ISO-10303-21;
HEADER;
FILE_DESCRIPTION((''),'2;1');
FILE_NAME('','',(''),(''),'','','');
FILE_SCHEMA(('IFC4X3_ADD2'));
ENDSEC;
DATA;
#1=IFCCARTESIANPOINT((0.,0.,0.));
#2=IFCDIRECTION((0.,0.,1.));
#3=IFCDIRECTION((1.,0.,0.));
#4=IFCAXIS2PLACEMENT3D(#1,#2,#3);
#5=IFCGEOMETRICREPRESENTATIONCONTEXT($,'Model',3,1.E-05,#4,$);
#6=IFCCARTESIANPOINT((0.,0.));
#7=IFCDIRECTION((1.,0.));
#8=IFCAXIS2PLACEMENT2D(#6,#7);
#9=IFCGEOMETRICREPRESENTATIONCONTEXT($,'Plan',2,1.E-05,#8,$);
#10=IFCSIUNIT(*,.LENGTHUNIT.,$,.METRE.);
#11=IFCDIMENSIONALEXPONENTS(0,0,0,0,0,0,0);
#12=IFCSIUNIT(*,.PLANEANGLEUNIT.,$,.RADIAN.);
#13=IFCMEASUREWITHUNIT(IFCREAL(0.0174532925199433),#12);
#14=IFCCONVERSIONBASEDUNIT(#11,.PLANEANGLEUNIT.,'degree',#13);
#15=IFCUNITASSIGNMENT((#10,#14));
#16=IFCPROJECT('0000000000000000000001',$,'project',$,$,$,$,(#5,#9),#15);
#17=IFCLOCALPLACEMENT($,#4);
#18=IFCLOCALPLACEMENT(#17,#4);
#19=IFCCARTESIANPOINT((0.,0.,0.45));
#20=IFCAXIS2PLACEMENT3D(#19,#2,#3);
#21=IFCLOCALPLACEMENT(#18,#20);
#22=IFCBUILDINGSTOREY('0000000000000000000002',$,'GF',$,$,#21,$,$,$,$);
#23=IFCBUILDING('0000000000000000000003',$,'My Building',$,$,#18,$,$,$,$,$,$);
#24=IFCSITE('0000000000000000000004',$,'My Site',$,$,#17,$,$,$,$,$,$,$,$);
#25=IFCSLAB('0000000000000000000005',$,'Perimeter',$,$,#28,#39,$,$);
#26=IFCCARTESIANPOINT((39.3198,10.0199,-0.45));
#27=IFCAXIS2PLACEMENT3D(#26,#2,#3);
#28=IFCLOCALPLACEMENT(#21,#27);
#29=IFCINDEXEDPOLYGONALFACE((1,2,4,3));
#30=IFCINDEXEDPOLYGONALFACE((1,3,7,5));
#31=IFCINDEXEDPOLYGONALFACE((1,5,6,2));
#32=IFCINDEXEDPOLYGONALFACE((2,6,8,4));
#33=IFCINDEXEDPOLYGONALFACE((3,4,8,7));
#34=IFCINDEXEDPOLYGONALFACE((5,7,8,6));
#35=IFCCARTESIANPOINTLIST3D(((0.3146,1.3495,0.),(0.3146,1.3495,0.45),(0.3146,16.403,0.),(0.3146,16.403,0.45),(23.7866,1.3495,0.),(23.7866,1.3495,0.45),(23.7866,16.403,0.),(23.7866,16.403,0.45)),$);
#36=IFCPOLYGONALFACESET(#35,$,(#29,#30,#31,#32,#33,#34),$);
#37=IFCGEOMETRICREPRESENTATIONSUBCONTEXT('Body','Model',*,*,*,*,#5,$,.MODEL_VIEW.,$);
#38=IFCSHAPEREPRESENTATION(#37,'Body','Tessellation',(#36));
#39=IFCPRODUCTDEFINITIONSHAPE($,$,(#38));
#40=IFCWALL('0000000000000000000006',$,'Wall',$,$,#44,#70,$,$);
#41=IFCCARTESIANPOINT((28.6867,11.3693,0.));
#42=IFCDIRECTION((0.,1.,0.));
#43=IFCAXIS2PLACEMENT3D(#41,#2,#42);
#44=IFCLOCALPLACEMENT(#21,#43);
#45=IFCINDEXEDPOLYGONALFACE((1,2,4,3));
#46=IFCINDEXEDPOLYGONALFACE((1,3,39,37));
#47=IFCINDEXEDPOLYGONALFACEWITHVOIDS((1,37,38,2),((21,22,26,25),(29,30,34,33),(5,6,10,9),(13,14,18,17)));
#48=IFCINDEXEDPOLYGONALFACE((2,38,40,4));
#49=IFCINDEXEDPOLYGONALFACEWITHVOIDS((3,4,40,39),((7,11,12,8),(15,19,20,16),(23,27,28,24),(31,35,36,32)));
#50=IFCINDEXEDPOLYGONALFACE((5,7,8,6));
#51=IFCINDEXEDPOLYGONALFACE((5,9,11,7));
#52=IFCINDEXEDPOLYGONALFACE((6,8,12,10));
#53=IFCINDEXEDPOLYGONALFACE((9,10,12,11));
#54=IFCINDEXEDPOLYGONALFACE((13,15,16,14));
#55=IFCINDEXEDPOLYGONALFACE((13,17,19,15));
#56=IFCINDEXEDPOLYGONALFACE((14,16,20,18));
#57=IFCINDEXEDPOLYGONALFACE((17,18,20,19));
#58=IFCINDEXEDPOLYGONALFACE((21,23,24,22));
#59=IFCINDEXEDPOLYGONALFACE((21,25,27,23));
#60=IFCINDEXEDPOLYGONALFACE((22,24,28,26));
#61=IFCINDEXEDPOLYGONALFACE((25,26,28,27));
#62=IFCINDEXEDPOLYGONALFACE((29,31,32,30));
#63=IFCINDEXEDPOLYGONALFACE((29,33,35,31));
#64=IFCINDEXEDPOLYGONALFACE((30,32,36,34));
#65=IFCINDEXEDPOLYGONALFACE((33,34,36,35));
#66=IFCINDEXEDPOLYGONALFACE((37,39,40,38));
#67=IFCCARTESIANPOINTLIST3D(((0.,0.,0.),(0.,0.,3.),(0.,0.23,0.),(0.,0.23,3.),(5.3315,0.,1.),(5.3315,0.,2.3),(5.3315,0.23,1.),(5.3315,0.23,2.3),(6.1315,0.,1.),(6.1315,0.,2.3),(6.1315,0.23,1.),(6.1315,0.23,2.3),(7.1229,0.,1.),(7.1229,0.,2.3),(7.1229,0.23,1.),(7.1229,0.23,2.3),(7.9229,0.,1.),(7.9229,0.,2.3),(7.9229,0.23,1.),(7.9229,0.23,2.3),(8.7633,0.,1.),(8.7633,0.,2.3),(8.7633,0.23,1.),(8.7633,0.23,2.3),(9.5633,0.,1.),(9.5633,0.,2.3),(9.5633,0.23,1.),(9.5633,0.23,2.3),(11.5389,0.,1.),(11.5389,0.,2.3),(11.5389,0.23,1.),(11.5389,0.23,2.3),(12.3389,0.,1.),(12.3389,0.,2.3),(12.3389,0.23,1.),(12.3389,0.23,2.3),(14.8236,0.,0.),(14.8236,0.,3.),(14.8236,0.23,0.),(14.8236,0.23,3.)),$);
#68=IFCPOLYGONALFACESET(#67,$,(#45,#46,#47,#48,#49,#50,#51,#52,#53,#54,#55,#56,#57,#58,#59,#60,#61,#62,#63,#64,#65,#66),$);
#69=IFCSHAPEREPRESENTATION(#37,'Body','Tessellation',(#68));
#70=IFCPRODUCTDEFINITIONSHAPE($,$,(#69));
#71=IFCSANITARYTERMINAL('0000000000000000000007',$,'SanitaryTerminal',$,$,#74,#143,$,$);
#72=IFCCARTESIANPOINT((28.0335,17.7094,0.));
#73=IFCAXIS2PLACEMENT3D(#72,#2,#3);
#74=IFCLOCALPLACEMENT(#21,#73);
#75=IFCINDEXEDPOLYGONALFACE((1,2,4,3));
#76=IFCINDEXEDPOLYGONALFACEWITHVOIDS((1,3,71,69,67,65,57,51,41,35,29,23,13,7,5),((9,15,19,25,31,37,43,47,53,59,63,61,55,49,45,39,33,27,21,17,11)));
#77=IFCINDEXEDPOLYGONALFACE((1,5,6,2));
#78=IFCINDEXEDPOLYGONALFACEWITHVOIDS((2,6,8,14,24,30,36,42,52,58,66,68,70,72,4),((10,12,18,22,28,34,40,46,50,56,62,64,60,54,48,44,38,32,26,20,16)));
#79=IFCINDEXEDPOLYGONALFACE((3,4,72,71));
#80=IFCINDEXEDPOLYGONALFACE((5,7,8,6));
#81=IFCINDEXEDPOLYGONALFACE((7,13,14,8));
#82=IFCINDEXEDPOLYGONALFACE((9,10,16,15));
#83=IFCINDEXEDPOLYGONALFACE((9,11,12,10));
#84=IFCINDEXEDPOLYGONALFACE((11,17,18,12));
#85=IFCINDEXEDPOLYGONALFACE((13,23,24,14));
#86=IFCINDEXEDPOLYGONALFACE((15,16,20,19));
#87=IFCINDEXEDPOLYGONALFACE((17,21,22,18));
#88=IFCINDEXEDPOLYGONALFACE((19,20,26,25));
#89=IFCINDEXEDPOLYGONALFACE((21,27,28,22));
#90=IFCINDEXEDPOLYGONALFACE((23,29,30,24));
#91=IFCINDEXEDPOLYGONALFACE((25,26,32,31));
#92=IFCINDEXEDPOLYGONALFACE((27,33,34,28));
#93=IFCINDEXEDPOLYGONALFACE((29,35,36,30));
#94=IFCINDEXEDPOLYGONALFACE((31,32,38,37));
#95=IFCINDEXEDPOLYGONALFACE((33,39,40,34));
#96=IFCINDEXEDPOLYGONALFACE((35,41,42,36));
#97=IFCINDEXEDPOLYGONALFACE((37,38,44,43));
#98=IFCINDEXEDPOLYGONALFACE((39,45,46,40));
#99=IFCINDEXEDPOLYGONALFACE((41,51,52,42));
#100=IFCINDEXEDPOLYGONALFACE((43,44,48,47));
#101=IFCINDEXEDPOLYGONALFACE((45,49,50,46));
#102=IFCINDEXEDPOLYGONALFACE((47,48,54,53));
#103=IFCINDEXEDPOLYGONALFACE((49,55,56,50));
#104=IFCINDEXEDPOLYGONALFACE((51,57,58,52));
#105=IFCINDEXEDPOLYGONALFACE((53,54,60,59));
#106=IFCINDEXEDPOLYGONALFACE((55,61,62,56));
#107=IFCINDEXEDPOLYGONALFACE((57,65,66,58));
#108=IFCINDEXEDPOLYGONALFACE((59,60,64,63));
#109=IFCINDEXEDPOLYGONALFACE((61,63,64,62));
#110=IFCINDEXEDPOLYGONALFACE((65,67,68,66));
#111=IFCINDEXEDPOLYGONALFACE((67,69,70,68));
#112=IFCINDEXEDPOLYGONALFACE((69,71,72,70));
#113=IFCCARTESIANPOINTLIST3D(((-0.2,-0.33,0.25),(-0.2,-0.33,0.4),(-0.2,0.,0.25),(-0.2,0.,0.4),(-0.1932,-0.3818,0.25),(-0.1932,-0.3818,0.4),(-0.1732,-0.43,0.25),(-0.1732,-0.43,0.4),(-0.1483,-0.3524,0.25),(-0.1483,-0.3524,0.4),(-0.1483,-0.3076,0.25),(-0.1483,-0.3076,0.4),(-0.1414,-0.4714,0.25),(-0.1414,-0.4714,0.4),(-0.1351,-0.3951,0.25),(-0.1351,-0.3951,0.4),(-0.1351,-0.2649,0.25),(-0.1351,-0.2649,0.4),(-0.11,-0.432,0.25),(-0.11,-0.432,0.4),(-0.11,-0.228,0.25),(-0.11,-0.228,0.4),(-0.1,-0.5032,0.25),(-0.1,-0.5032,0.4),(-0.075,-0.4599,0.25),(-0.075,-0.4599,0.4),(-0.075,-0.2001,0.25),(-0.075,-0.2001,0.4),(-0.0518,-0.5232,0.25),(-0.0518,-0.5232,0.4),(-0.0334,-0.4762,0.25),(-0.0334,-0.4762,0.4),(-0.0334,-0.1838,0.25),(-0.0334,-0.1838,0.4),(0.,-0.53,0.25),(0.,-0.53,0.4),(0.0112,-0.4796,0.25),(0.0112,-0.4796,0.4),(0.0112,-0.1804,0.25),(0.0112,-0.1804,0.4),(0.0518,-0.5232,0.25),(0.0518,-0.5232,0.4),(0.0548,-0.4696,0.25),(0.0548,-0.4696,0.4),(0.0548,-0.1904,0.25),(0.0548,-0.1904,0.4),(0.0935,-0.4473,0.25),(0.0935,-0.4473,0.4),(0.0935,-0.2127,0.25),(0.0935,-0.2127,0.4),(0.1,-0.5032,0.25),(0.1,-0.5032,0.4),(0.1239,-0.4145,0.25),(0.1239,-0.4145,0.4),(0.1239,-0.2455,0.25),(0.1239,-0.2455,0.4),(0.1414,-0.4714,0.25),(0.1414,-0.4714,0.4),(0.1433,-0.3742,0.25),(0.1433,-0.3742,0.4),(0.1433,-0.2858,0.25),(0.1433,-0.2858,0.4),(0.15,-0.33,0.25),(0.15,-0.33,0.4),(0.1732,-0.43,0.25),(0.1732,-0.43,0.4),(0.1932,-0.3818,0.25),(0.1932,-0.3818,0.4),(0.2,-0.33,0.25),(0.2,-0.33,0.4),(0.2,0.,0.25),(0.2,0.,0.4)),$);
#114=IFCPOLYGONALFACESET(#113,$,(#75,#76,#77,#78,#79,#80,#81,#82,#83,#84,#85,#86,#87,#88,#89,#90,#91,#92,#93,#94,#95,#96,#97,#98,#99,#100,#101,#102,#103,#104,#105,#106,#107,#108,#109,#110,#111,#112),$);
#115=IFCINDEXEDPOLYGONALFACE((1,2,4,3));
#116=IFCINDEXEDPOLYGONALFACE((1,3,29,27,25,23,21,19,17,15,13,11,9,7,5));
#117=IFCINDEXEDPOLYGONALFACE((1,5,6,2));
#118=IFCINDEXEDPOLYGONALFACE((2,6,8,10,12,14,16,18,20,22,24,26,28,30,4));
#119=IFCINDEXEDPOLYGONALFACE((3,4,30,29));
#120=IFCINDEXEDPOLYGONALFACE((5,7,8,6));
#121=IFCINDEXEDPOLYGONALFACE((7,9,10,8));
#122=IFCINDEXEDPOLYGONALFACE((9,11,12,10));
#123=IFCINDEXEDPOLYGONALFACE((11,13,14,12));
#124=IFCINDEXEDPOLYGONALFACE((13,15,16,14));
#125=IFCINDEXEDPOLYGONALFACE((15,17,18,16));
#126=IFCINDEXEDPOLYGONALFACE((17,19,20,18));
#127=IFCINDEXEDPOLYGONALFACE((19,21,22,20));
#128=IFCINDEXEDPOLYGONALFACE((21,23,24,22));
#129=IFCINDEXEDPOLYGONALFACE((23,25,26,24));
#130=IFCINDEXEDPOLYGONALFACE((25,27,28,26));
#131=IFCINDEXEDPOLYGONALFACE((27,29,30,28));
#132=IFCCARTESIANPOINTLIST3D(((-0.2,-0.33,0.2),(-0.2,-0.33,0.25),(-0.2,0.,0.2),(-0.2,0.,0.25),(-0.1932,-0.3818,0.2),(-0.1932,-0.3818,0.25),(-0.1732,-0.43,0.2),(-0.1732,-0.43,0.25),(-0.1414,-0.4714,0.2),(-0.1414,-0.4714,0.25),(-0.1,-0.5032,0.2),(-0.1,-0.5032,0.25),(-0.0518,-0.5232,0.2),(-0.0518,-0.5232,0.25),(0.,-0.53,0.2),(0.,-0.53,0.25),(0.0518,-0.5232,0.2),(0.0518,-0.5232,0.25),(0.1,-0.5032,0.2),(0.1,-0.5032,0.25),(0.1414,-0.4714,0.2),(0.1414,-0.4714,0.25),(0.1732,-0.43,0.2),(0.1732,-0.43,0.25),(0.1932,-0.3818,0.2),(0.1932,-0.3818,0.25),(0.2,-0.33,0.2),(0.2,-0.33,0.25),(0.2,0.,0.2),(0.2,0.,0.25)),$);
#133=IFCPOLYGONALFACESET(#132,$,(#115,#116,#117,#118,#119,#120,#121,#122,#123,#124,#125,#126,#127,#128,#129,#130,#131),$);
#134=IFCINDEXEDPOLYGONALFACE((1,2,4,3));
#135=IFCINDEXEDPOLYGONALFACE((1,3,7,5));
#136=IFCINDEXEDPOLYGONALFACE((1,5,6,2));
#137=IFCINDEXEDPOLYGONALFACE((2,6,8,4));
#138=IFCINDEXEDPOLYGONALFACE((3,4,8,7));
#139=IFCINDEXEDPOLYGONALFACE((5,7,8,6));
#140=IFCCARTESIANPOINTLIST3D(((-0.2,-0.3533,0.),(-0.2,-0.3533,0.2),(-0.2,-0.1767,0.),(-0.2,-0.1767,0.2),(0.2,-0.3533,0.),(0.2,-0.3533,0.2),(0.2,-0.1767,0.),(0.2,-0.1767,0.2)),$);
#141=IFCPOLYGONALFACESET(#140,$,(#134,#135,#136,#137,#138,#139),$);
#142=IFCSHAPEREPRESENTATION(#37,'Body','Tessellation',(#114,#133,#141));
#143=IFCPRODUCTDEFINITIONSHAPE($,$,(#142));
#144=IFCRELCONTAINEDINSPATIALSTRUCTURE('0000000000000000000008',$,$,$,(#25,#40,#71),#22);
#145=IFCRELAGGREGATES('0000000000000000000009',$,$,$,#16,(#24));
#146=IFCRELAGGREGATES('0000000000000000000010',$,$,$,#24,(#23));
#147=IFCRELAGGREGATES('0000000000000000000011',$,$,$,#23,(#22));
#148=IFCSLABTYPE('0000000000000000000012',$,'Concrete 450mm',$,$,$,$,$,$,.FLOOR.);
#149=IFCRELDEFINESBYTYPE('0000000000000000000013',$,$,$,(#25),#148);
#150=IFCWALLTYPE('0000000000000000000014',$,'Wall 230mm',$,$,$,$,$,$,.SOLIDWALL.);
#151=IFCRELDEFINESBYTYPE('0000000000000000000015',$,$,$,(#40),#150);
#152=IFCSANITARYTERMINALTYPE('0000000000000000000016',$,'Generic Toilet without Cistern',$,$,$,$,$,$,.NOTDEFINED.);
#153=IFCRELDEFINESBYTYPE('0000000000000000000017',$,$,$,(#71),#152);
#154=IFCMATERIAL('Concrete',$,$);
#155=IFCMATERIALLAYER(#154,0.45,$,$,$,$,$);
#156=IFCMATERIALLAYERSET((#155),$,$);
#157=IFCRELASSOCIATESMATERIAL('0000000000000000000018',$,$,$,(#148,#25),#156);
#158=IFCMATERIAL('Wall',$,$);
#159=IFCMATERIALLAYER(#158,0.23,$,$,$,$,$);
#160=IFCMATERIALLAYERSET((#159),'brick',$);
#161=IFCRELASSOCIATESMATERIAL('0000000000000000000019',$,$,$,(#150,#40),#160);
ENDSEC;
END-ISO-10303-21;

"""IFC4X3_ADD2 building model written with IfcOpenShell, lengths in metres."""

from ifc_helpers import new_model, entity, si_unit, converted_unit, frame, frame_2d, origin_with_axes, origin_2d_with_axis, place, context, subcontext, project, spatial, line, arc, indexed_curve, circle_curve, outline, extrude, shape, source, transform, mapped, material, layer, layer_set, layer_usage, type_object, type_shapes, element, save


model = new_model("IFC4X3_ADD2")

# Units and contexts
model_context = context("Model", 3, precision=1e-05, world=origin_with_axes())
plan_context = context("Plan", 2, precision=1e-05, world=origin_2d_with_axis())
body_context_1 = subcontext(model_context, "Body", "Model", "MODEL_VIEW")
body_context_2 = subcontext(plan_context, "Body", "Plan", "PLAN_VIEW")
ifc_project = project(units=[si_unit("LENGTHUNIT", "METRE"), converted_unit("PLANEANGLEUNIT", "degree", entity("IfcReal", 0.0174532925199433), si_unit("PLANEANGLEUNIT", "RADIAN"), dimensions=[0, 0, 0, 0, 0, 0, 0])], contexts=[model_context, plan_context])

# Site, building, storey
site_placement = place(None, origin_with_axes())
site = spatial("IfcSite", under=ifc_project, at=site_placement, Name="My Site")
building_placement = place(site_placement, origin_with_axes())
building = spatial("IfcBuilding", under=site, at=building_placement, Name="My Building")
storey_placement = place(building_placement, frame((0.0, 0.0, 0.45), z_axis=(0.0, 0.0, 1.0), x_axis=(1.0, 0.0, 0.0)))
storey = spatial("IfcBuildingStorey", under=building, at=storey_placement, Name="GF")

# Slab
ifc_material_1 = material(Name="Concrete")
ifc_layer_1 = layer(ifc_material_1, 0.45)
ifc_layer_set_1 = layer_set([ifc_layer_1])
ifc_layer_usage_1 = layer_usage(ifc_layer_set_1, "AXIS3", "POSITIVE", 0.0)
slab_type = type_object("IfcSlabType", Name="Concrete 450mm", PredefinedType="FLOOR", material=ifc_layer_set_1)
slab_placement = place(storey_placement, frame((39.3198, 10.0199, -0.45), z_axis=(0.0, 0.0, 1.0), x_axis=(1.0, 0.0, 0.0)))
element("IfcSlab", 1, at=slab_placement, inside=storey, type_object=slab_type, material=ifc_layer_usage_1, Name="Perimeter", context=body_context_1, shape_type="SweptSolid", body=[
    extrude(outline(indexed_curve([(23.7866, 1.3495), (23.7866, 16.403), (0.3146, 16.403), (0.3146, 1.3495)], segments=[line(3, 2), line(2, 1), line(1, 4), line(4, 3)], self_intersect=False)), None, (0.0, 0.0, 1.0), 0.45),
])

# Shared definitions
ifc_material_2 = material(Name="Wall")
ifc_layer_2 = layer(ifc_material_2, 0.23)
ifc_layer_set_2 = layer_set([ifc_layer_2], Name="brick")
wall_type_1 = type_object("IfcWallType", Name="Wall 230mm", PredefinedType="SOLIDWALL", material=ifc_layer_set_2)

# Wall, openings
ifc_layer_usage_2 = layer_usage(ifc_layer_set_2, "AXIS2", "POSITIVE", 0.0)
wall_1_placement = place(storey_placement, frame((28.6867, 11.3693, 0.0), z_axis=(0.0, 0.0, 1.0), x_axis=(0.0, 1.0, 0.0)))
wall_1 = element("IfcWall", 2, at=wall_1_placement, inside=storey, type_object=wall_type_1, material=ifc_layer_usage_2, Name="Wall", context=body_context_1, shape_type="SweptSolid", body=[
    extrude(outline(indexed_curve([(0.0, 0.0), (0.0, 0.23), (14.8236, 0.23), (14.8236, 0.0), (0.0, 0.0)], self_intersect=False)), origin_with_axes(), (0.0, 0.0, 1.0), 3.0),
])
shared_shape_1 = source(origin_with_axes(), body_context_1, "Body", "SweptSolid", [
    extrude(outline(indexed_curve([(0.0, 0.0), (0.8, 0.0), (0.8, 1.3), (0.0, 1.3)], segments=[line(1, 2, 3, 4, 1)])), frame((-0.4, -0.6, 0.0), z_axis=(0.0, -1.0, 0.0), x_axis=(1.0, 0.0, 0.0)), (0.0, 0.0, -1.0), 1.2),
])
opening_1_placement = place(wall_1_placement, frame((9.1633, 0.16, 1.0), z_axis=(0.0, 0.0, 1.0), x_axis=(1.0, 0.0, 0.0)))
element("IfcOpeningElement", 3, at=opening_1_placement, cuts=wall_1, PredefinedType="OPENING", context=body_context_1, shape_type="MappedRepresentation", body=[
    mapped(shared_shape_1, transform((0.0, 0.0, 0.0), x_axis=(1.0, 0.0, 0.0), y_axis=(0.0, 1.0, 0.0), z_axis=(0.0, 0.0, 1.0), scale=1.0)),
])
opening_2_placement = place(wall_1_placement, frame((11.9389, 0.16, 1.0), z_axis=(0.0, 0.0, 1.0), x_axis=(1.0, 0.0, 0.0)))
element("IfcOpeningElement", 4, at=opening_2_placement, cuts=wall_1, PredefinedType="OPENING", context=body_context_1, shape_type="MappedRepresentation", body=[
    mapped(shared_shape_1, transform((0.0, 0.0, 0.0), x_axis=(1.0, 0.0, 0.0), y_axis=(0.0, 1.0, 0.0), z_axis=(0.0, 0.0, 1.0), scale=1.0)),
])
opening_3_placement = place(wall_1_placement, frame((5.7315, 0.23, 1.0), z_axis=(0.0, 0.0, 1.0), x_axis=(-1.0, 0.0, 0.0)))
element("IfcOpeningElement", 5, at=opening_3_placement, cuts=wall_1, PredefinedType="OPENING", context=body_context_1, shape_type="MappedRepresentation", body=[
    mapped(shared_shape_1, transform((0.0, 0.0, 0.0), x_axis=(1.0, 0.0, 0.0), y_axis=(0.0, 1.0, 0.0), z_axis=(0.0, 0.0, 1.0), scale=1.0)),
])
opening_4_placement = place(wall_1_placement, frame((7.5229, 0.16, 1.0), z_axis=(0.0, 0.0, 1.0), x_axis=(-1.0, 0.0, 0.0)))
element("IfcOpeningElement", 6, at=opening_4_placement, cuts=wall_1, PredefinedType="OPENING", context=body_context_1, shape_type="MappedRepresentation", body=[
    mapped(shared_shape_1, transform((0.0, 0.0, 0.0), x_axis=(1.0, 0.0, 0.0), y_axis=(0.0, 1.0, 0.0), z_axis=(0.0, 0.0, 1.0), scale=1.0)),
])

# Sanitary terminal
sanitary_terminal_type_1 = type_object("IfcSanitaryTerminalType", Name="Generic Toilet without Cistern", PredefinedType="NOTDEFINED")
shared_shape_2 = source(origin_with_axes(), body_context_1, "Body", "SweptSolid", [
    extrude(outline(indexed_curve([(-0.2, 0.0), (0.2, 0.0), (0.2, -0.33), (0.1414, -0.4714), (0.0, -0.53), (-0.1414, -0.4714), (-0.2, -0.33)], segments=[line(1, 2), line(2, 3), arc(3, 4, 5), arc(5, 6, 7), line(7, 1)]), holes=[circle_curve(frame_2d((0.0, -0.33)), 0.15)]), frame((0.0, 0.0, 0.25), z_axis=(0.0, 0.0, 1.0), x_axis=(1.0, 0.0, 0.0)), (0.0, 0.0, 1.0), 0.15),
    extrude(outline(indexed_curve([(-0.2, 0.0), (0.2, 0.0), (0.2, -0.33), (0.1414, -0.4714), (0.0, -0.53), (-0.1414, -0.4714), (-0.2, -0.33)], segments=[line(1, 2), line(2, 3), arc(3, 4, 5), arc(5, 6, 7), line(7, 1)])), frame((0.0, 0.0, 0.2), z_axis=(0.0, 0.0, 1.0), x_axis=(1.0, 0.0, 0.0)), (0.0, 0.0, 1.0), 0.05),
    extrude(outline(indexed_curve([(-0.2, -0.1767), (0.2, -0.1767), (0.2, -0.3533), (-0.2, -0.3533)], segments=[line(1, 2, 3, 4, 1)])), origin_with_axes(), (0.0, 0.0, 1.0), 0.2),
])
shared_shape_3 = source(origin_with_axes(), body_context_2, "Body", "Annotation2D", [
    entity("IfcGeometricCurveSet", [entity("IfcIndexedPolyCurve", entity("IfcCartesianPointList2D", [[-0.1068, -0.124], [-0.0957, -0.1129], [-0.0804, -0.1088], [0.0804, -0.1088], [0.0957, -0.1129], [0.1068, -0.124], [0.1109, -0.1393], [0.1109, -0.3476], [0.1025, -0.3926], [0.0784, -0.4308], [0.0424, -0.4563], [0.0, -0.4652], [-0.0424, -0.4563], [-0.0784, -0.4308], [-0.1025, -0.3926], [-0.1109, -0.3476], [-0.1109, -0.1393]]), [entity("IfcLineIndex", [1, 2, 3, 4, 5, 6, 7, 8, 9, 10, 11, 12, 13, 14, 15, 16, 17, 1])]), entity("IfcIndexedPolyCurve", entity("IfcCartesianPointList2D", [[-0.1962, -0.2314], [-0.1848, -0.301], [-0.1764, -0.3339], [-0.1663, -0.3651], [-0.1546, -0.3944], [-0.1414, -0.4213], [-0.1269, -0.4458], [-0.1111, -0.4675], [-0.0943, -0.4862], [-0.0765, -0.5018], [-0.0581, -0.514], [-0.039, -0.5229], [-0.0196, -0.5282], [0.0, -0.53], [0.0196, -0.5282], [0.039, -0.5229], [0.0581, -0.514], [0.0765, -0.5018], [0.0943, -0.4862], [0.1111, -0.4675], [0.1269, -0.4458], [0.1414, -0.4213], [0.1546, -0.3944], [0.1663, -0.3651], [0.1764, -0.3339], [0.1848, -0.301], [0.1962, -0.2314], [0.2, -0.159], [0.1872, 0.0], [-0.1872, 0.0], [-0.2, -0.159]]), [entity("IfcLineIndex", [1, 2, 3, 4, 5, 6, 7, 8, 9, 10, 11, 12, 13, 14, 15, 16, 17, 18, 19, 20, 21, 22, 23, 24, 25, 26, 27, 28, 29, 30, 31, 1])])]),
])
type_shapes(sanitary_terminal_type_1, [shared_shape_2, shared_shape_3])
for number, where, z_axis, x_axis, name in (
    (7, (28.0335, 17.7094, 0.0), (0.0, 0.0, 1.0), (1.0, 0.0, 0.0), "SanitaryTerminal"),
):
    element("IfcSanitaryTerminal", number, at=place(storey_placement, frame(where, z_axis=z_axis, x_axis=x_axis)), inside=storey, type_object=sanitary_terminal_type_1, Name=name, shapes=[
        shape(body_context_1, "Body", "MappedRepresentation", [mapped(shared_shape_2, transform((0.0, 0.0, 0.0), x_axis=(1.0, 0.0, 0.0), y_axis=(0.0, 1.0, 0.0), z_axis=(0.0, 0.0, 1.0), scale=1.0))]),
        shape(body_context_2, "Body", "MappedRepresentation", [mapped(shared_shape_3, transform((0.0, 0.0, 0.0), x_axis=(1.0, 0.0, 0.0), y_axis=(0.0, 1.0, 0.0), z_axis=(0.0, 0.0, 1.0), scale=1.0))]),
    ])

save(model, "model.ifc")
